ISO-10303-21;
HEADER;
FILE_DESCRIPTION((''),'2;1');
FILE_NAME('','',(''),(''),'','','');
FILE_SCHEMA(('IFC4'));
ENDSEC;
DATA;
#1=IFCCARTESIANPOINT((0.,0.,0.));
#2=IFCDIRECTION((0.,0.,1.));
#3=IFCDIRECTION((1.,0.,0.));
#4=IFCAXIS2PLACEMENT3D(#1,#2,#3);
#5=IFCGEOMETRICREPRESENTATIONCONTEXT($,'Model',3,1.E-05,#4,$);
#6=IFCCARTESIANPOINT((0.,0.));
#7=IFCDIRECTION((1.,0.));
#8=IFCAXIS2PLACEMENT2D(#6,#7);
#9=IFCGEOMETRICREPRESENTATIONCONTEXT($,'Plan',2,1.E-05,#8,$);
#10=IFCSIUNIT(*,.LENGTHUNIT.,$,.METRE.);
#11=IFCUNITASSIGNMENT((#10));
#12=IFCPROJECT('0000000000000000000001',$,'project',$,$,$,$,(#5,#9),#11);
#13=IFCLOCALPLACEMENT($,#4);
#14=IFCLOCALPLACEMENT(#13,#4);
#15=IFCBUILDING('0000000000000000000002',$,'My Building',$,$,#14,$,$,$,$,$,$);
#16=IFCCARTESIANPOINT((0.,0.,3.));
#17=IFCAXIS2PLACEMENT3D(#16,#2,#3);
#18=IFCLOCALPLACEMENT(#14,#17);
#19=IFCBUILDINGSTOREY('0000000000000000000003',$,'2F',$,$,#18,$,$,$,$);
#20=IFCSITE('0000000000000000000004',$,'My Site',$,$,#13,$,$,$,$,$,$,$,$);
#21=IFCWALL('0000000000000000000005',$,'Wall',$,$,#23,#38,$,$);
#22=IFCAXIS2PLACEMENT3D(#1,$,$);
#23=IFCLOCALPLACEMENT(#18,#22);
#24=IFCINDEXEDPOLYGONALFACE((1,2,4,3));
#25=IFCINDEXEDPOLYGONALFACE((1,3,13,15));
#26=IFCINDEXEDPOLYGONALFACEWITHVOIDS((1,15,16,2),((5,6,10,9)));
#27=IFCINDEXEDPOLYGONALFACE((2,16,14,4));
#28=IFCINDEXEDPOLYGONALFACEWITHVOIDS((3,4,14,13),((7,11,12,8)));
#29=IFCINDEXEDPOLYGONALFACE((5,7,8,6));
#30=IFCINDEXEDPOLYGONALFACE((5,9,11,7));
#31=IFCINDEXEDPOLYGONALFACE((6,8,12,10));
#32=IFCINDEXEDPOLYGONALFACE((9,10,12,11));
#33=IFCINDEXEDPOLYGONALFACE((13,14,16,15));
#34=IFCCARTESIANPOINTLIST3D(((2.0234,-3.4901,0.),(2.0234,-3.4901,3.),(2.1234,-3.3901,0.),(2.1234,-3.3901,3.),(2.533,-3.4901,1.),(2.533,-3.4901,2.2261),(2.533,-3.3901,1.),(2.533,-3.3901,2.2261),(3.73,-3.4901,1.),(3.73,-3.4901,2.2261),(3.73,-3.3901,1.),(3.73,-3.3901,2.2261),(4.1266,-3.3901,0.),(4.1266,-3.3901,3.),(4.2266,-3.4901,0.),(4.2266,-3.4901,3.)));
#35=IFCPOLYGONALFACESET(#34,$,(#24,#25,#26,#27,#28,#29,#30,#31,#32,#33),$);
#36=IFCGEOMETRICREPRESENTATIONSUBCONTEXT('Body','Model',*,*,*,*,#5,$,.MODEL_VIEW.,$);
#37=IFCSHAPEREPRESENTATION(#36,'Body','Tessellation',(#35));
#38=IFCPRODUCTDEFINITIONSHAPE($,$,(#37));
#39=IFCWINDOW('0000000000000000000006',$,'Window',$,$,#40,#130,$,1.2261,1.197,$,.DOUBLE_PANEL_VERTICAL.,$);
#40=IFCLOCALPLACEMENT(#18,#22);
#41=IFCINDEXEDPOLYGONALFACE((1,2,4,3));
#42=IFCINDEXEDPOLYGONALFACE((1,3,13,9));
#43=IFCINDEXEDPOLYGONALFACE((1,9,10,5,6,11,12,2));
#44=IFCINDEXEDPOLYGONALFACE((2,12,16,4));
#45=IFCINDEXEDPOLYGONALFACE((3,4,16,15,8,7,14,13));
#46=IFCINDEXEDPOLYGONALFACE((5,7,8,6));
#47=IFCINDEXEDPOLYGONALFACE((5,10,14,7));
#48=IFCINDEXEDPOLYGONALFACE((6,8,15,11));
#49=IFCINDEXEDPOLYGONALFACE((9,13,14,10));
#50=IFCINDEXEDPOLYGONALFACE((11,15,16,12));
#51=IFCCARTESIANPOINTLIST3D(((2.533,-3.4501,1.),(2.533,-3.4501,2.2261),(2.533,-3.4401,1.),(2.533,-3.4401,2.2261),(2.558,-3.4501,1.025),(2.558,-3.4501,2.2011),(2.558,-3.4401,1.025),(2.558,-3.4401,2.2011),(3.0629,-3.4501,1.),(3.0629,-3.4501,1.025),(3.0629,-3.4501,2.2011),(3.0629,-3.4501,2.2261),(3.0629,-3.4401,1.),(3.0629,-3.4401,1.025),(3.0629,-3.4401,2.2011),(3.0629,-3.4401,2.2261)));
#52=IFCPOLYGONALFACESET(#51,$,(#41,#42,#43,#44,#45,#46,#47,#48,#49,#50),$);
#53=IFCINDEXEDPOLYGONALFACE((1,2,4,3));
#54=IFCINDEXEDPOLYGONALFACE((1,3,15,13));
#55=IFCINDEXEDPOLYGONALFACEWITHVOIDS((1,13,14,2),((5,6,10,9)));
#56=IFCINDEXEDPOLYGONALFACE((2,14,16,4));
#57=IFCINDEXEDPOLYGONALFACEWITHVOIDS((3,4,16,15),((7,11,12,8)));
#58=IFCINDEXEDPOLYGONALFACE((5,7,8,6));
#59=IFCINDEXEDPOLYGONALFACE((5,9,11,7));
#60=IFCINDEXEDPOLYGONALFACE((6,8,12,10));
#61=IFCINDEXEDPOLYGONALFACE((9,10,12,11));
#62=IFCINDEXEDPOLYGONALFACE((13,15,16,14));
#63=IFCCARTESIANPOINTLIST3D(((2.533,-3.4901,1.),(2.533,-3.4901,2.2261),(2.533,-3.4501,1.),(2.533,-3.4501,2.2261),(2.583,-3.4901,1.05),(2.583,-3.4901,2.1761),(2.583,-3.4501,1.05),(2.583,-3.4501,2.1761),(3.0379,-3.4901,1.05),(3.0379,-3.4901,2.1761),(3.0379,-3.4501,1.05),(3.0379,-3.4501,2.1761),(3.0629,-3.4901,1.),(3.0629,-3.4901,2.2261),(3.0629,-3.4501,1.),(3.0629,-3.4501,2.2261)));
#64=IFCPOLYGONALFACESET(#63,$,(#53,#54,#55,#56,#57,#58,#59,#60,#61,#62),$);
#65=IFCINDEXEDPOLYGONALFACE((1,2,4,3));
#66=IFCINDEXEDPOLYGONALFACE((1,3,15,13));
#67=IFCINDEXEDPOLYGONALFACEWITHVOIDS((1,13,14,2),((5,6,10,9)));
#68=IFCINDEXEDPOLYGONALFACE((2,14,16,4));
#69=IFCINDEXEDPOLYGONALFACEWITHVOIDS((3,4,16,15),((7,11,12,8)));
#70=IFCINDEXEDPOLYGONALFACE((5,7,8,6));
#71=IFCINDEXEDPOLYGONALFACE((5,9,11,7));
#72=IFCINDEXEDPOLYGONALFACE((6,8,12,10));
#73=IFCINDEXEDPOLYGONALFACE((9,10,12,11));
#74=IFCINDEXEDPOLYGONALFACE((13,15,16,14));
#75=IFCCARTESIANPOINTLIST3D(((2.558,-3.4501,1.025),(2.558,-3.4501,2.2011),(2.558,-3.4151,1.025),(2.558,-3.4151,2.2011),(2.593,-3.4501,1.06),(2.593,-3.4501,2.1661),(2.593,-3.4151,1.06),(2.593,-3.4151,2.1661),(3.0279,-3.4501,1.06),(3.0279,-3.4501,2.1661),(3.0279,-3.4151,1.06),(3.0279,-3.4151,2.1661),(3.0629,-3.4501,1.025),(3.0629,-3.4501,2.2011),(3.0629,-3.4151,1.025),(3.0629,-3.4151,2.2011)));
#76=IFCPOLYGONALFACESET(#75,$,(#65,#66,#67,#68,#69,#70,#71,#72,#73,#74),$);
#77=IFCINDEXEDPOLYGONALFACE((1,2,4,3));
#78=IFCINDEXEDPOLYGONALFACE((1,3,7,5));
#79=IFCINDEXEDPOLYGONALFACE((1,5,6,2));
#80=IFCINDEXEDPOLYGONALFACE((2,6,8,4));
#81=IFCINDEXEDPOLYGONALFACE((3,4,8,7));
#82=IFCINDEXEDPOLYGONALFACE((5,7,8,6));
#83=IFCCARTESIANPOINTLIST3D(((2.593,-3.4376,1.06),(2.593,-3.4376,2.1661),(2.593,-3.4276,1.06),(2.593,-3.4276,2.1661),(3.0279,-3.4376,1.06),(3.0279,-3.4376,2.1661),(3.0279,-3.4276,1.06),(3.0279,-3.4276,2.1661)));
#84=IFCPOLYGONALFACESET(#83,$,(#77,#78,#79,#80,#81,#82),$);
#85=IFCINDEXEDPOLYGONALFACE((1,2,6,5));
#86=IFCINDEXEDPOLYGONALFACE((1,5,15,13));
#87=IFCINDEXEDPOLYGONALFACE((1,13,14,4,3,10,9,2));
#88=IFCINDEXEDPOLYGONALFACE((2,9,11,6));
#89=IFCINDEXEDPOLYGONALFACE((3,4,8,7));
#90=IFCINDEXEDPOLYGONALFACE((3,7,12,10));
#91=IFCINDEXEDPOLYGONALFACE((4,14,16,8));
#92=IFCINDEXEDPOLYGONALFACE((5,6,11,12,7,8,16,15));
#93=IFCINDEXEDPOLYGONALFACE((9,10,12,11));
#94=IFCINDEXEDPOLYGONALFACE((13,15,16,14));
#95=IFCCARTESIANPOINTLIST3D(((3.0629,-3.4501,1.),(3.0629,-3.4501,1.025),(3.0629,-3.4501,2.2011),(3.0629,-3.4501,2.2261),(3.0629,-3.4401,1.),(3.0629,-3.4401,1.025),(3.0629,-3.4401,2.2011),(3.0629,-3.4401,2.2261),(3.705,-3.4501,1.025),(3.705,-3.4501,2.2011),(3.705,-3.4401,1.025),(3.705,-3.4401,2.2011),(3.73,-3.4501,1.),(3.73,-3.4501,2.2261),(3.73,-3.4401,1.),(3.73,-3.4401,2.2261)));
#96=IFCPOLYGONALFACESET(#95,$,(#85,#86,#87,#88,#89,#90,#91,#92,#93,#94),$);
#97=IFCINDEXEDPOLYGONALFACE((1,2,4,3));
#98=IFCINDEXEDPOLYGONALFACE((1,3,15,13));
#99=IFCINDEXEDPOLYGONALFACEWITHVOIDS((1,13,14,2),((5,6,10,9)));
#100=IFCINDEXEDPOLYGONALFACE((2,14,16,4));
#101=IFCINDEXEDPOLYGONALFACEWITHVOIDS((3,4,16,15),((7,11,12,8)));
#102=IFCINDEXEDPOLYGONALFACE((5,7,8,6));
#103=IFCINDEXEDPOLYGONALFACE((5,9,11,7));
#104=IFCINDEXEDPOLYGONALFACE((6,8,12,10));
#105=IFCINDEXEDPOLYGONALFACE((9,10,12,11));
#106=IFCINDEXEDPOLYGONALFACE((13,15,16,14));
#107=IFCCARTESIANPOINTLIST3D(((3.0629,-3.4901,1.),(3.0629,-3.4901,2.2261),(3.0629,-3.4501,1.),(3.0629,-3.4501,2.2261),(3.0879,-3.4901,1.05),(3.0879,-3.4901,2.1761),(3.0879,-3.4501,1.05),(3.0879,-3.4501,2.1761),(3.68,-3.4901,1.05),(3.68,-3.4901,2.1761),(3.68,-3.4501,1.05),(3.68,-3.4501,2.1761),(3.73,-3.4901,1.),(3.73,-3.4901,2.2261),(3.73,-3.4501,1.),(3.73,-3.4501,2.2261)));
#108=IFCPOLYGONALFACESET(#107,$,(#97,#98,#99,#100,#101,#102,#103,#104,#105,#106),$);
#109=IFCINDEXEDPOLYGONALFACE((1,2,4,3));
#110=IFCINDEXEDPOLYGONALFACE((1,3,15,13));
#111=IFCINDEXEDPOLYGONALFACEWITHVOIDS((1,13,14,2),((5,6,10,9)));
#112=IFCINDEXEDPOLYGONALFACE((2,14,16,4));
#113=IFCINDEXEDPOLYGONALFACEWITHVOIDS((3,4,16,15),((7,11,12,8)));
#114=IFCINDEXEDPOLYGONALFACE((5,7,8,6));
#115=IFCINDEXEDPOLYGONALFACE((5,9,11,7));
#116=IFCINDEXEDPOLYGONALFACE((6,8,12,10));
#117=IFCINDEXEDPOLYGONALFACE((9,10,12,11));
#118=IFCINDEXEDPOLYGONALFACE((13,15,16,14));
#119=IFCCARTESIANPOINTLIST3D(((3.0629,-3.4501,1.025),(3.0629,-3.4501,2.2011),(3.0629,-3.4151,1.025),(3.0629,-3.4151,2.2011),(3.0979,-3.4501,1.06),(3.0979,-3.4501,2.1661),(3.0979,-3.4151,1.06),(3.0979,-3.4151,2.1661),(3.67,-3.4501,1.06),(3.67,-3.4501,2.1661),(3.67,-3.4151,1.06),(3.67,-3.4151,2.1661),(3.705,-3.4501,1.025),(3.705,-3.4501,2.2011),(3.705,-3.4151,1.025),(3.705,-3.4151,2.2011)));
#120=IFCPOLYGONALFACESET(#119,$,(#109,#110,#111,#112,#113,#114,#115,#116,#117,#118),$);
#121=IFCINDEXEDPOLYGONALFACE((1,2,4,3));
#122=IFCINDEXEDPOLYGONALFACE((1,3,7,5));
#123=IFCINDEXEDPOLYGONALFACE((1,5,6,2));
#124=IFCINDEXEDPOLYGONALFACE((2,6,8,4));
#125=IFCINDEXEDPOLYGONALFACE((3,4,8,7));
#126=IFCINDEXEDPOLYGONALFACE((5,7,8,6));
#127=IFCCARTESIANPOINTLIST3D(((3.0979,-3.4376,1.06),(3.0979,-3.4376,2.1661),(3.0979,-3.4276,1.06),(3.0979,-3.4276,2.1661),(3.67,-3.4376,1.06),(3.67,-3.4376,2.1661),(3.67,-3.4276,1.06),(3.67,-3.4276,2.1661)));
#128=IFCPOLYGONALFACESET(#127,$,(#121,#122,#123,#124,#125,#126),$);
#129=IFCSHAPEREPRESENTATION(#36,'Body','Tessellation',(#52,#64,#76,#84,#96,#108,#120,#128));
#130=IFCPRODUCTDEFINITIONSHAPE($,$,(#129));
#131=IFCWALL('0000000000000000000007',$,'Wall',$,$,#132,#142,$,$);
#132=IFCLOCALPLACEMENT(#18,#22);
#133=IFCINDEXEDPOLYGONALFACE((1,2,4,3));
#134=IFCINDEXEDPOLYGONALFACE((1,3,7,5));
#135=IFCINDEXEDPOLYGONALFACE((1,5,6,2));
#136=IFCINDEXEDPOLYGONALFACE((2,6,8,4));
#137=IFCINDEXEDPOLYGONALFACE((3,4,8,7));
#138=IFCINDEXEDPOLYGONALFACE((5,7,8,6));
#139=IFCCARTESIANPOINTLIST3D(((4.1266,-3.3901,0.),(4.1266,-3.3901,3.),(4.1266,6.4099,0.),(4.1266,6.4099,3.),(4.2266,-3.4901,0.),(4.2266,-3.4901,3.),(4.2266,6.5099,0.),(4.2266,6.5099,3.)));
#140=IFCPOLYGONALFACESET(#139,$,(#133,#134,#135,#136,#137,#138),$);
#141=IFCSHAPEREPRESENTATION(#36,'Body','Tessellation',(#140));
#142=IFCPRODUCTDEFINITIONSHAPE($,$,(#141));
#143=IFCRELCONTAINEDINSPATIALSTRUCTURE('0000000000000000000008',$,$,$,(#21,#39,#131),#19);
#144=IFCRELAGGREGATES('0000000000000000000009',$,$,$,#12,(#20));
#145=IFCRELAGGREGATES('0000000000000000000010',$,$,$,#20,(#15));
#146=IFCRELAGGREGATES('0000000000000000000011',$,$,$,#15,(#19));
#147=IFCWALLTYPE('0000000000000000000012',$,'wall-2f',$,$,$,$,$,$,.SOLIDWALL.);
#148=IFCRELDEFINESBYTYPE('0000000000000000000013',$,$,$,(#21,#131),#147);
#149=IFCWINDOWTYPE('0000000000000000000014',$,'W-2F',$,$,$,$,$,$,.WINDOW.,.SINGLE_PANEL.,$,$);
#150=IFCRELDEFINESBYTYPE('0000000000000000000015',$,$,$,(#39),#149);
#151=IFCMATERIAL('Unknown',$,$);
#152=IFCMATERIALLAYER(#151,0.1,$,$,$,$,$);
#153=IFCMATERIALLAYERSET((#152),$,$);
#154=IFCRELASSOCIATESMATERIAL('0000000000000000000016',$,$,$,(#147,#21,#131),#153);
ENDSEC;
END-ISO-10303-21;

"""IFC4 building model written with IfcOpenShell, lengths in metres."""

from ifc_helpers import new_model, entity, si_unit, frame, origin_with_axes, origin_2d_with_axis, place, context, subcontext, project, spatial, line, indexed_curve, outline, extrude, shape, source, transform, mapped, material, layer, layer_set, layer_usage, type_object, type_shapes, element, fill, save


model = new_model("IFC4")

# Units and contexts
model_context = context("Model", 3, precision=1e-05, world=origin_with_axes())
plan_context = context("Plan", 2, precision=1e-05, world=origin_2d_with_axis())
body_context_1 = subcontext(model_context, "Body", "Model", "MODEL_VIEW")
body_context_2 = subcontext(plan_context, "Body", "Plan", "PLAN_VIEW")
ifc_project = project(units=[si_unit("LENGTHUNIT", "METRE")], contexts=[model_context, plan_context])

# Site, building, storey
site_placement = place(None, origin_with_axes())
site = spatial("IfcSite", under=ifc_project, at=site_placement, Name="My Site")
building_placement = place(site_placement, origin_with_axes())
building = spatial("IfcBuilding", under=site, at=building_placement, Name="My Building")
storey_placement = place(building_placement, frame((0.0, 0.0, 3.0), z_axis=(0.0, 0.0, 1.0), x_axis=(1.0, 0.0, 0.0)))
storey = spatial("IfcBuildingStorey", under=building, at=storey_placement, Name="2F")

# Shared definitions
ifc_material = material(Name="Unknown")
ifc_layer_1 = layer(ifc_material, 0.1)
ifc_layer_set_1 = layer_set([ifc_layer_1])
wall_type_1 = type_object("IfcWallType", Name="wall-2f", PredefinedType="SOLIDWALL", material=ifc_layer_set_1)

# Wall, opening, window
ifc_layer_usage_1 = layer_usage(ifc_layer_set_1, "AXIS2", "POSITIVE", 0.0)
wall_1_placement = place(storey_placement, frame((2.0234, -3.4901, 0.0), z_axis=(0.0, 0.0, 1.0), x_axis=(1.0, 0.0, 0.0)))
wall_1 = element("IfcWall", 1, at=wall_1_placement, inside=storey, type_object=wall_type_1, material=ifc_layer_usage_1, Name="Wall", context=body_context_1, shape_type="SweptSolid", body=[
    extrude(outline(indexed_curve([(0.0, 0.0), (0.1, 0.1), (2.1032, 0.1), (2.2032, 0.0)], segments=[line(1, 2, 3, 4, 1)])), origin_with_axes(), (0.0, 0.0, 1.0), 3.0),
])
shared_shape_1 = source(origin_with_axes(), body_context_1, "Body", "SweptSolid", [
    extrude(outline(indexed_curve([(0.0, 0.0), (1.197, 0.0), (1.197, 1.2261), (0.0, 1.2261)], segments=[line(1, 2, 3, 4, 1)])), frame((0.0, -0.6, 0.0), z_axis=(0.0, -1.0, 0.0), x_axis=(1.0, 0.0, 0.0)), (0.0, 0.0, -1.0), 1.2),
])
opening_1_placement = place(wall_1_placement, frame((0.5096, -0.05, 1.0), z_axis=(0.0, 0.0, 1.0), x_axis=(1.0, 0.0, 0.0)))
opening_1 = element("IfcOpeningElement", 2, at=opening_1_placement, cuts=wall_1, PredefinedType="OPENING", context=body_context_1, shape_type="MappedRepresentation", body=[
    mapped(shared_shape_1, transform((0.0, 0.0, 0.0), x_axis=(1.0, 0.0, 0.0), y_axis=(0.0, 1.0, 0.0), z_axis=(0.0, 0.0, 1.0), scale=1.0)),
])
window_type_1 = type_object("IfcWindowType", Name="W-2F", PartitioningType="SINGLE_PANEL", PredefinedType="WINDOW")
shared_shape_2 = source(origin_with_axes(), body_context_1, "Body", "SweptSolid", [
    extrude(outline(indexed_curve([(0.5299, 0.0), (0.0, 0.0), (0.0, 1.2261), (0.5299, 1.2261), (0.5299, 1.2011), (0.025, 1.2011), (0.025, 0.025), (0.5299, 0.025)], segments=[line(1, 2, 3, 4, 5, 6, 7, 8, 1)])), frame((0.0, 0.09, 0.0), z_axis=(0.0, -1.0, 0.0), x_axis=(1.0, 0.0, 0.0)), (0.0, 0.0, -1.0), 0.01),
    extrude(outline(indexed_curve([(0.0, 0.0), (0.5299, 0.0), (0.5299, 1.2261), (0.0, 1.2261)], segments=[line(1, 2, 3, 4, 1)]), holes=[indexed_curve([(0.05, 0.05), (0.5049, 0.05), (0.5049, 1.1761), (0.05, 1.1761)], segments=[line(1, 2, 3, 4, 1)])]), frame((0.0, 0.05, 0.0), z_axis=(0.0, -1.0, 0.0), x_axis=(1.0, 0.0, 0.0)), (0.0, 0.0, -1.0), 0.04),
    extrude(outline(indexed_curve([(0.0, 0.0), (0.5049, 0.0), (0.5049, 1.1761), (0.0, 1.1761)], segments=[line(1, 2, 3, 4, 1)]), holes=[indexed_curve([(0.035, 0.035), (0.4699, 0.035), (0.4699, 1.1411), (0.035, 1.1411)], segments=[line(1, 2, 3, 4, 1)])]), frame((0.025, 0.09, 0.025), z_axis=(0.0, -1.0, 0.0), x_axis=(1.0, 0.0, 0.0)), (0.0, 0.0, -1.0), 0.035),
    extrude(outline(indexed_curve([(0.035, 0.035), (0.4699, 0.035), (0.4699, 1.1411), (0.035, 1.1411)], segments=[line(1, 2, 3, 4, 1)])), frame((0.025, 0.1025, 0.025), z_axis=(0.0, -1.0, 0.0), x_axis=(1.0, 0.0, 0.0)), (0.0, 0.0, -1.0), 0.01),
    extrude(outline(indexed_curve([(0.0, 1.2261), (0.6671, 1.2261), (0.6671, 0.0), (0.0, 0.0), (0.0, 0.025), (0.6421, 0.025), (0.6421, 1.2011), (0.0, 1.2011)], segments=[line(1, 2, 3, 4, 5, 6, 7, 8, 1)])), frame((0.5299, 0.09, 0.0), z_axis=(0.0, -1.0, 0.0), x_axis=(1.0, 0.0, 0.0)), (0.0, 0.0, -1.0), 0.01),
    extrude(outline(indexed_curve([(0.0, 0.0), (0.6671, 0.0), (0.6671, 1.2261), (0.0, 1.2261)], segments=[line(1, 2, 3, 4, 1)]), holes=[indexed_curve([(0.025, 0.05), (0.6171, 0.05), (0.6171, 1.1761), (0.025, 1.1761)], segments=[line(1, 2, 3, 4, 1)])]), frame((0.5299, 0.05, 0.0), z_axis=(0.0, -1.0, 0.0), x_axis=(1.0, 0.0, 0.0)), (0.0, 0.0, -1.0), 0.04),
    extrude(outline(indexed_curve([(0.0, 0.0), (0.6421, 0.0), (0.6421, 1.1761), (0.0, 1.1761)], segments=[line(1, 2, 3, 4, 1)]), holes=[indexed_curve([(0.035, 0.035), (0.6071, 0.035), (0.6071, 1.1411), (0.035, 1.1411)], segments=[line(1, 2, 3, 4, 1)])]), frame((0.5299, 0.09, 0.025), z_axis=(0.0, -1.0, 0.0), x_axis=(1.0, 0.0, 0.0)), (0.0, 0.0, -1.0), 0.035),
    extrude(outline(indexed_curve([(0.035, 0.035), (0.6071, 0.035), (0.6071, 1.1411), (0.035, 1.1411)], segments=[line(1, 2, 3, 4, 1)])), frame((0.5299, 0.1025, 0.025), z_axis=(0.0, -1.0, 0.0), x_axis=(1.0, 0.0, 0.0)), (0.0, 0.0, -1.0), 0.01),
])
shared_shape_3 = source(origin_with_axes(), body_context_2, "Body", "Curve2D", [
    entity("IfcIndexedPolyCurve", entity("IfcCartesianPointList2D", [[0.05, 0.05], [0.5049, 0.05]])),
    entity("IfcIndexedPolyCurve", entity("IfcCartesianPointList2D", [[0.0, 0.1], [0.025, 0.1], [0.025, 0.09], [0.05, 0.09], [0.05, 0.05], [0.0, 0.05]]), [entity("IfcLineIndex", [1, 2, 3, 4, 5, 6, 1])]),
    entity("IfcIndexedPolyCurve", entity("IfcCartesianPointList2D", [[0.5299, 0.1], [0.5299, 0.1], [0.5299, 0.09], [0.5049, 0.09], [0.5049, 0.05], [0.5299, 0.05]])),
    entity("IfcIndexedPolyCurve", entity("IfcCartesianPointList2D", [[0.025, 0.09], [0.06, 0.09], [0.06, 0.125], [0.025, 0.125]]), [entity("IfcLineIndex", [1, 2, 3, 4, 1])]),
    entity("IfcIndexedPolyCurve", entity("IfcCartesianPointList2D", [[0.5299, 0.09], [0.4949, 0.09], [0.4949, 0.125], [0.5299, 0.125]]), [entity("IfcLineIndex", [1, 2, 3, 4, 1])]),
    entity("IfcIndexedPolyCurve", entity("IfcCartesianPointList2D", [[0.06, 0.09], [0.4949, 0.09]])),
    entity("IfcIndexedPolyCurve", entity("IfcCartesianPointList2D", [[0.06, 0.125], [0.4949, 0.125]])),
    entity("IfcIndexedPolyCurve", entity("IfcCartesianPointList2D", [[0.06, 0.1075], [0.4949, 0.1075]])),
    entity("IfcIndexedPolyCurve", entity("IfcCartesianPointList2D", [[0.5549, 0.05], [1.147, 0.05]])),
    entity("IfcIndexedPolyCurve", entity("IfcCartesianPointList2D", [[0.5299, 0.1], [0.5299, 0.1], [0.5299, 0.09], [0.5549, 0.09], [0.5549, 0.05], [0.5299, 0.05]])),
    entity("IfcIndexedPolyCurve", entity("IfcCartesianPointList2D", [[1.197, 0.1], [1.172, 0.1], [1.172, 0.09], [1.147, 0.09], [1.147, 0.05], [1.197, 0.05]]), [entity("IfcLineIndex", [1, 2, 3, 4, 5, 6, 1])]),
    entity("IfcIndexedPolyCurve", entity("IfcCartesianPointList2D", [[0.5299, 0.09], [0.5649, 0.09], [0.5649, 0.125], [0.5299, 0.125]]), [entity("IfcLineIndex", [1, 2, 3, 4, 1])]),
    entity("IfcIndexedPolyCurve", entity("IfcCartesianPointList2D", [[1.172, 0.09], [1.137, 0.09], [1.137, 0.125], [1.172, 0.125]]), [entity("IfcLineIndex", [1, 2, 3, 4, 1])]),
    entity("IfcIndexedPolyCurve", entity("IfcCartesianPointList2D", [[0.5649, 0.09], [1.137, 0.09]])),
    entity("IfcIndexedPolyCurve", entity("IfcCartesianPointList2D", [[0.5649, 0.125], [1.137, 0.125]])),
    entity("IfcIndexedPolyCurve", entity("IfcCartesianPointList2D", [[0.5649, 0.1075], [1.137, 0.1075]])),
])
type_shapes(window_type_1, [shared_shape_2, shared_shape_3])
window_1_placement = place(opening_1_placement, frame((0.0, 0.0, 0.0), z_axis=(0.0, 0.0, 1.0), x_axis=(1.0, 0.0, 0.0)))
window_1 = element("IfcWindow", 3, at=window_1_placement, inside=storey, type_object=window_type_1, Name="Window", OverallHeight=1.2261, OverallWidth=1.197, PartitioningType="DOUBLE_PANEL_VERTICAL", shapes=[
    shape(body_context_1, "Body", "MappedRepresentation", [mapped(shared_shape_2, transform((0.0, 0.0, 0.0), x_axis=(1.0, 0.0, 0.0), y_axis=(0.0, 1.0, 0.0), z_axis=(0.0, 0.0, 1.0), scale=1.0))]),
    shape(body_context_2, "Body", "MappedRepresentation", [mapped(shared_shape_3, transform((0.0, 0.0, 0.0), x_axis=(1.0, 0.0, 0.0), y_axis=(0.0, 1.0, 0.0), z_axis=(0.0, 0.0, 1.0), scale=1.0))]),
])
fill(opening_1, window_1)

# Wall
ifc_layer_usage_2 = layer_usage(ifc_layer_set_1, "AXIS2", "POSITIVE", 0.0)
wall_2_placement = place(storey_placement, frame((4.2266, -3.4901, 0.0), z_axis=(0.0, 0.0, 1.0), x_axis=(0.0, 1.0, 0.0)))
element("IfcWall", 4, at=wall_2_placement, inside=storey, type_object=wall_type_1, material=ifc_layer_usage_2, Name="Wall", context=body_context_1, shape_type="SweptSolid", body=[
    extrude(outline(indexed_curve([(0.0, 0.0), (0.1, 0.1), (9.9, 0.1), (10.0, 0.0)], segments=[line(1, 2, 3, 4, 1)])), origin_with_axes(), (0.0, 0.0, 1.0), 3.0),
])

save(model, "model.ifc")
